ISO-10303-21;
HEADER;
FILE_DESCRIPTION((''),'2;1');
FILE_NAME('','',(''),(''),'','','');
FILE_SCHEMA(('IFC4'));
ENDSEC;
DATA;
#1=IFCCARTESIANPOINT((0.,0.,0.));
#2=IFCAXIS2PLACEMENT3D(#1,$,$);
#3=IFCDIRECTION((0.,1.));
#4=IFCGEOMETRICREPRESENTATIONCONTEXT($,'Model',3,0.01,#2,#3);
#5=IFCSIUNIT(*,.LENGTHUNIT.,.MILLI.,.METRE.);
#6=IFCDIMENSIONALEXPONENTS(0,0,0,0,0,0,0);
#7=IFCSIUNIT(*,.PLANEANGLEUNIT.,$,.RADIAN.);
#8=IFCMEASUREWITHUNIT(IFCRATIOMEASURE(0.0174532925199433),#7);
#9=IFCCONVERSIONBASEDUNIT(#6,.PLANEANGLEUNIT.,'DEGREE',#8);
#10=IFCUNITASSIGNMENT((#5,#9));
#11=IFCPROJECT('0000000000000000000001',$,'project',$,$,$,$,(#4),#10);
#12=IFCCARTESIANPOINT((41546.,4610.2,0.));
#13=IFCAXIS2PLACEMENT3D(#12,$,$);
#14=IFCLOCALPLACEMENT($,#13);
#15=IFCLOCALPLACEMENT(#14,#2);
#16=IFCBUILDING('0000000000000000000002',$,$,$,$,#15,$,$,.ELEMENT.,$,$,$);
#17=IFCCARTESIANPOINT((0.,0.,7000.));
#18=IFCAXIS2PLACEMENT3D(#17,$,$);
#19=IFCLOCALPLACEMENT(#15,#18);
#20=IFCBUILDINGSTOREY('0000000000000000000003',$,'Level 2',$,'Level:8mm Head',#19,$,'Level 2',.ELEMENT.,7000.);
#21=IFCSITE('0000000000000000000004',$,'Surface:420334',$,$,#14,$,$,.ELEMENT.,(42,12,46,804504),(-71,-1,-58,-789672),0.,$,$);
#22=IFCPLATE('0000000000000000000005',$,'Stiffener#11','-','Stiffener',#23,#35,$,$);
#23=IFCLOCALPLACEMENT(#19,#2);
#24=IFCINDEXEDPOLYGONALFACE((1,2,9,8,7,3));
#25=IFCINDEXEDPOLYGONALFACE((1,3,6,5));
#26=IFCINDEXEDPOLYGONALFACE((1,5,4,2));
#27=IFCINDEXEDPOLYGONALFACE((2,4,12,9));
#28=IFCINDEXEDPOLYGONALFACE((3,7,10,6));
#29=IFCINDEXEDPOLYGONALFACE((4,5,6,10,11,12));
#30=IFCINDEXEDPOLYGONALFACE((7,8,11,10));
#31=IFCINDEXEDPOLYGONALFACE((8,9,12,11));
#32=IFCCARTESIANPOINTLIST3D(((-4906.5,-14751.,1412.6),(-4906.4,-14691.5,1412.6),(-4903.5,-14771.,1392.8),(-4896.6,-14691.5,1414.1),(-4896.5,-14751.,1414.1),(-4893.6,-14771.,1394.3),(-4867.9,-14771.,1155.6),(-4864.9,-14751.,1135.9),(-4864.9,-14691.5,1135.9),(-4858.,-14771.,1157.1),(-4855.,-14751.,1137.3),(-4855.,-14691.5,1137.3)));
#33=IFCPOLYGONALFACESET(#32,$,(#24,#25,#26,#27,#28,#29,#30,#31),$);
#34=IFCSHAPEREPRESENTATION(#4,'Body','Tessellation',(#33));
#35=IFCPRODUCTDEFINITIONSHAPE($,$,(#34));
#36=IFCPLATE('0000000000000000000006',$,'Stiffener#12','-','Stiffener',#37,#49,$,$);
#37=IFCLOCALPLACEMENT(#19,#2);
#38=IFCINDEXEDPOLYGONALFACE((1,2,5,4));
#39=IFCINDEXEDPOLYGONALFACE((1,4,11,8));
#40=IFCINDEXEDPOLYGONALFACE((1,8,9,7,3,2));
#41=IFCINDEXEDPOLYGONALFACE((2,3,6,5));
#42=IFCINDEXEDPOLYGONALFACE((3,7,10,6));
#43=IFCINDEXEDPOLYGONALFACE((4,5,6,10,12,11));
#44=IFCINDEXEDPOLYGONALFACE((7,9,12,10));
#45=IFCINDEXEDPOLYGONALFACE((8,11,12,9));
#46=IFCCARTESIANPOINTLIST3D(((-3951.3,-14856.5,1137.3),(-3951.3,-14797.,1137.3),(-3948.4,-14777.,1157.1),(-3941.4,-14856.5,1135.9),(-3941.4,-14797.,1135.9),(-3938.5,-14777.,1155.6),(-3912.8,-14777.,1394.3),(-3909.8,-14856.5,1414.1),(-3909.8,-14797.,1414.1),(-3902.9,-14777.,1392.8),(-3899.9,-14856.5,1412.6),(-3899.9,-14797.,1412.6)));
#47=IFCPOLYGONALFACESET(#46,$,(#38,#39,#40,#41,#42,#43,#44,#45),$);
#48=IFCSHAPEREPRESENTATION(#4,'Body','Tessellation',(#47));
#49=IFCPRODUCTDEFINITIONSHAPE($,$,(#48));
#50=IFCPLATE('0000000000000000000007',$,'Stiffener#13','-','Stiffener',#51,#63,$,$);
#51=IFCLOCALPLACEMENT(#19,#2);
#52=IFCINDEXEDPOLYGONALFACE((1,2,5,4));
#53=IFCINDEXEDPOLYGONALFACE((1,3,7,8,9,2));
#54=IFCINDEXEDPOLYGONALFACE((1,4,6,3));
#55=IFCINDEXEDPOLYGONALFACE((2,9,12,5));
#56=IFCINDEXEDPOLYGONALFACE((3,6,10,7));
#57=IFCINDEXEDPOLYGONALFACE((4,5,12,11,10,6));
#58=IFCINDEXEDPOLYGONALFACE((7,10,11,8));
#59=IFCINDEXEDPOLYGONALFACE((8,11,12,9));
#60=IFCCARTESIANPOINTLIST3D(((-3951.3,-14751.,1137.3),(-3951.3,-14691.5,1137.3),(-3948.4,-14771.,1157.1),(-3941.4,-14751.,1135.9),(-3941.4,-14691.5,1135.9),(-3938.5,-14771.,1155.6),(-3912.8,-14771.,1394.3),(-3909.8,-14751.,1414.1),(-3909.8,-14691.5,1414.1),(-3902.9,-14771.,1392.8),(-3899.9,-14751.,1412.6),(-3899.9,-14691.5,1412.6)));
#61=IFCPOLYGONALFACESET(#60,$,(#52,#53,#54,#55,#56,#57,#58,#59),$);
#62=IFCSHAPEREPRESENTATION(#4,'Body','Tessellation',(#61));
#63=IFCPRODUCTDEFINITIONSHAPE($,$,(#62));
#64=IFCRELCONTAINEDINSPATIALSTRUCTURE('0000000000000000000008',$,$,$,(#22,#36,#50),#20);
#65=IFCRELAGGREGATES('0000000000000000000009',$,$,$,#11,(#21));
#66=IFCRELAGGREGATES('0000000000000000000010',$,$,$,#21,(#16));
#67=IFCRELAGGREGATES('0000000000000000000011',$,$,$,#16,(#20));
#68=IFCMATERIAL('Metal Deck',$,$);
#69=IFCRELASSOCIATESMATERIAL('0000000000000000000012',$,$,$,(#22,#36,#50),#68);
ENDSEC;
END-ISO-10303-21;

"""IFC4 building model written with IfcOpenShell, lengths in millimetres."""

from ifc_helpers import new_model, entity, si_unit, converted_unit, direction, frame, origin, origin_with_axes, place, context, project, spatial, polyline, outline, extrude, material, element, save


model = new_model("IFC4")

# Units and contexts
model_context = context("Model", 3, precision=0.01, world=origin(), true_north=direction((0.0, 1.0)))
ifc_project = project(units=[si_unit("LENGTHUNIT", "METRE", prefix="MILLI"), converted_unit("PLANEANGLEUNIT", "DEGREE", entity("IfcRatioMeasure", 0.0174532925199433), si_unit("PLANEANGLEUNIT", "RADIAN"), dimensions=[0, 0, 0, 0, 0, 0, 0])], contexts=[model_context])

# Site, building, storey
site_placement = place(None, frame((41546.0, 4610.2, 0.0)))
site = spatial("IfcSite", under=ifc_project, at=site_placement, Name="Surface:420334", CompositionType="ELEMENT", RefLatitude=(42, 12, 46, 804504), RefLongitude=(-71, -1, -58, -789672), RefElevation=0.0)
building_placement = place(site_placement, origin())
building = spatial("IfcBuilding", under=site, at=building_placement, CompositionType="ELEMENT")
storey_placement = place(building_placement, frame((0.0, 0.0, 7000.0)))
storey = spatial("IfcBuildingStorey", under=building, at=storey_placement, Name="Level 2", ObjectType="Level:8mm Head", LongName="Level 2", CompositionType="ELEMENT", Elevation=7000.0)

# Plates, openings
ifc_material = material(Name="Metal Deck")
plate_1_placement = place(storey_placement, frame((-4855.0, -14691.5, 1137.3), z_axis=(-0.988936, 0.0, -0.14834), x_axis=(0.0, -1.0, 0.0)))
plate_1 = element("IfcPlate", 1, at=plate_1_placement, inside=storey, material=ifc_material, Name="Stiffener#11", Description="-", ObjectType="Stiffener", context=model_context, shape_type="SweptSolid", body=[
    extrude(outline(polyline([(0.0, 0.0), (79.5, 0.0), (79.5, 279.8), (0.0, 279.8), (0.0, 0.0)])), origin_with_axes(), (0.0, 0.0, 1.0), 10.0),
])
opening_1_placement = place(plate_1_placement, frame((0.0, 0.0, 0.0), z_axis=(0.0, 0.0, 1.0), x_axis=(1.0, 0.0, 0.0)))
element("IfcOpeningElement", 2, at=opening_1_placement, cuts=plate_1, ObjectType="Opening", context=model_context, shape_type="SweptSolid", body=[
    extrude(outline(polyline([(79.5, 279.8), (59.5, 279.8), (79.5, 259.8), (79.5, 279.8)])), origin(), (0.0, 0.0, 1.0), 10.0),
])
opening_2_placement = place(plate_1_placement, frame((0.0, 0.0, 0.0), z_axis=(0.0, 0.0, 1.0), x_axis=(1.0, 0.0, 0.0)))
element("IfcOpeningElement", 3, at=opening_2_placement, cuts=plate_1, ObjectType="Opening", context=model_context, shape_type="SweptSolid", body=[
    extrude(outline(polyline([(79.5, 0.0), (79.5, 20.0), (59.5, 0.0), (79.5, 0.0)])), origin(), (0.0, 0.0, 1.0), 10.0),
])
plate_2_placement = place(storey_placement, frame((-3951.3, -14856.5, 1137.3), z_axis=(0.988936, 0.0, -0.14834), x_axis=(0.0, 1.0, 0.0)))
plate_2 = element("IfcPlate", 4, at=plate_2_placement, inside=storey, material=ifc_material, Name="Stiffener#12", Description="-", ObjectType="Stiffener", context=model_context, shape_type="SweptSolid", body=[
    extrude(outline(polyline([(0.0, 0.0), (79.5, 0.0), (79.5, 279.8), (0.0, 279.8), (0.0, 0.0)])), origin_with_axes(), (0.0, 0.0, 1.0), 10.0),
])
opening_3_placement = place(plate_2_placement, frame((0.0, 0.0, 0.0), z_axis=(0.0, 0.0, 1.0), x_axis=(1.0, 0.0, 0.0)))
element("IfcOpeningElement", 5, at=opening_3_placement, cuts=plate_2, ObjectType="Opening", context=model_context, shape_type="SweptSolid", body=[
    extrude(outline(polyline([(79.5, 279.8), (59.5, 279.8), (79.5, 259.8), (79.5, 279.8)])), origin(), (0.0, 0.0, 1.0), 10.0),
])
opening_4_placement = place(plate_2_placement, frame((0.0, 0.0, 0.0), z_axis=(0.0, 0.0, 1.0), x_axis=(1.0, 0.0, 0.0)))
element("IfcOpeningElement", 6, at=opening_4_placement, cuts=plate_2, ObjectType="Opening", context=model_context, shape_type="SweptSolid", body=[
    extrude(outline(polyline([(79.5, 0.0), (79.5, 20.0), (59.5, 0.0), (79.5, 0.0)])), origin(), (0.0, 0.0, 1.0), 10.0),
])
plate_3_placement = place(storey_placement, frame((-3951.3, -14771.0, 1137.3), z_axis=(0.988936, 0.0, -0.14834), x_axis=(0.0, 1.0, 0.0)))
plate_3 = element("IfcPlate", 7, at=plate_3_placement, inside=storey, material=ifc_material, Name="Stiffener#13", Description="-", ObjectType="Stiffener", context=model_context, shape_type="SweptSolid", body=[
    extrude(outline(polyline([(0.0, 0.0), (79.5, 0.0), (79.5, 279.8), (0.0, 279.8), (0.0, 0.0)])), origin_with_axes(), (0.0, 0.0, 1.0), 10.0),
])
opening_5_placement = place(plate_3_placement, frame((0.0, 0.0, 0.0), z_axis=(0.0, 0.0, 1.0), x_axis=(1.0, 0.0, 0.0)))
element("IfcOpeningElement", 8, at=opening_5_placement, cuts=plate_3, ObjectType="Opening", context=model_context, shape_type="SweptSolid", body=[
    extrude(outline(polyline([(0.0, 279.8), (0.0, 259.8), (20.0, 279.8), (0.0, 279.8)])), origin(), (0.0, 0.0, 1.0), 10.0),
])
opening_6_placement = place(plate_3_placement, frame((0.0, 0.0, 0.0), z_axis=(0.0, 0.0, 1.0), x_axis=(1.0, 0.0, 0.0)))
element("IfcOpeningElement", 9, at=opening_6_placement, cuts=plate_3, ObjectType="Opening", context=model_context, shape_type="SweptSolid", body=[
    extrude(outline(polyline([(0.0, 0.0), (20.0, 0.0), (0.0, 20.0), (0.0, 0.0)])), origin(), (0.0, 0.0, 1.0), 10.0),
])

save(model, "model.ifc")
